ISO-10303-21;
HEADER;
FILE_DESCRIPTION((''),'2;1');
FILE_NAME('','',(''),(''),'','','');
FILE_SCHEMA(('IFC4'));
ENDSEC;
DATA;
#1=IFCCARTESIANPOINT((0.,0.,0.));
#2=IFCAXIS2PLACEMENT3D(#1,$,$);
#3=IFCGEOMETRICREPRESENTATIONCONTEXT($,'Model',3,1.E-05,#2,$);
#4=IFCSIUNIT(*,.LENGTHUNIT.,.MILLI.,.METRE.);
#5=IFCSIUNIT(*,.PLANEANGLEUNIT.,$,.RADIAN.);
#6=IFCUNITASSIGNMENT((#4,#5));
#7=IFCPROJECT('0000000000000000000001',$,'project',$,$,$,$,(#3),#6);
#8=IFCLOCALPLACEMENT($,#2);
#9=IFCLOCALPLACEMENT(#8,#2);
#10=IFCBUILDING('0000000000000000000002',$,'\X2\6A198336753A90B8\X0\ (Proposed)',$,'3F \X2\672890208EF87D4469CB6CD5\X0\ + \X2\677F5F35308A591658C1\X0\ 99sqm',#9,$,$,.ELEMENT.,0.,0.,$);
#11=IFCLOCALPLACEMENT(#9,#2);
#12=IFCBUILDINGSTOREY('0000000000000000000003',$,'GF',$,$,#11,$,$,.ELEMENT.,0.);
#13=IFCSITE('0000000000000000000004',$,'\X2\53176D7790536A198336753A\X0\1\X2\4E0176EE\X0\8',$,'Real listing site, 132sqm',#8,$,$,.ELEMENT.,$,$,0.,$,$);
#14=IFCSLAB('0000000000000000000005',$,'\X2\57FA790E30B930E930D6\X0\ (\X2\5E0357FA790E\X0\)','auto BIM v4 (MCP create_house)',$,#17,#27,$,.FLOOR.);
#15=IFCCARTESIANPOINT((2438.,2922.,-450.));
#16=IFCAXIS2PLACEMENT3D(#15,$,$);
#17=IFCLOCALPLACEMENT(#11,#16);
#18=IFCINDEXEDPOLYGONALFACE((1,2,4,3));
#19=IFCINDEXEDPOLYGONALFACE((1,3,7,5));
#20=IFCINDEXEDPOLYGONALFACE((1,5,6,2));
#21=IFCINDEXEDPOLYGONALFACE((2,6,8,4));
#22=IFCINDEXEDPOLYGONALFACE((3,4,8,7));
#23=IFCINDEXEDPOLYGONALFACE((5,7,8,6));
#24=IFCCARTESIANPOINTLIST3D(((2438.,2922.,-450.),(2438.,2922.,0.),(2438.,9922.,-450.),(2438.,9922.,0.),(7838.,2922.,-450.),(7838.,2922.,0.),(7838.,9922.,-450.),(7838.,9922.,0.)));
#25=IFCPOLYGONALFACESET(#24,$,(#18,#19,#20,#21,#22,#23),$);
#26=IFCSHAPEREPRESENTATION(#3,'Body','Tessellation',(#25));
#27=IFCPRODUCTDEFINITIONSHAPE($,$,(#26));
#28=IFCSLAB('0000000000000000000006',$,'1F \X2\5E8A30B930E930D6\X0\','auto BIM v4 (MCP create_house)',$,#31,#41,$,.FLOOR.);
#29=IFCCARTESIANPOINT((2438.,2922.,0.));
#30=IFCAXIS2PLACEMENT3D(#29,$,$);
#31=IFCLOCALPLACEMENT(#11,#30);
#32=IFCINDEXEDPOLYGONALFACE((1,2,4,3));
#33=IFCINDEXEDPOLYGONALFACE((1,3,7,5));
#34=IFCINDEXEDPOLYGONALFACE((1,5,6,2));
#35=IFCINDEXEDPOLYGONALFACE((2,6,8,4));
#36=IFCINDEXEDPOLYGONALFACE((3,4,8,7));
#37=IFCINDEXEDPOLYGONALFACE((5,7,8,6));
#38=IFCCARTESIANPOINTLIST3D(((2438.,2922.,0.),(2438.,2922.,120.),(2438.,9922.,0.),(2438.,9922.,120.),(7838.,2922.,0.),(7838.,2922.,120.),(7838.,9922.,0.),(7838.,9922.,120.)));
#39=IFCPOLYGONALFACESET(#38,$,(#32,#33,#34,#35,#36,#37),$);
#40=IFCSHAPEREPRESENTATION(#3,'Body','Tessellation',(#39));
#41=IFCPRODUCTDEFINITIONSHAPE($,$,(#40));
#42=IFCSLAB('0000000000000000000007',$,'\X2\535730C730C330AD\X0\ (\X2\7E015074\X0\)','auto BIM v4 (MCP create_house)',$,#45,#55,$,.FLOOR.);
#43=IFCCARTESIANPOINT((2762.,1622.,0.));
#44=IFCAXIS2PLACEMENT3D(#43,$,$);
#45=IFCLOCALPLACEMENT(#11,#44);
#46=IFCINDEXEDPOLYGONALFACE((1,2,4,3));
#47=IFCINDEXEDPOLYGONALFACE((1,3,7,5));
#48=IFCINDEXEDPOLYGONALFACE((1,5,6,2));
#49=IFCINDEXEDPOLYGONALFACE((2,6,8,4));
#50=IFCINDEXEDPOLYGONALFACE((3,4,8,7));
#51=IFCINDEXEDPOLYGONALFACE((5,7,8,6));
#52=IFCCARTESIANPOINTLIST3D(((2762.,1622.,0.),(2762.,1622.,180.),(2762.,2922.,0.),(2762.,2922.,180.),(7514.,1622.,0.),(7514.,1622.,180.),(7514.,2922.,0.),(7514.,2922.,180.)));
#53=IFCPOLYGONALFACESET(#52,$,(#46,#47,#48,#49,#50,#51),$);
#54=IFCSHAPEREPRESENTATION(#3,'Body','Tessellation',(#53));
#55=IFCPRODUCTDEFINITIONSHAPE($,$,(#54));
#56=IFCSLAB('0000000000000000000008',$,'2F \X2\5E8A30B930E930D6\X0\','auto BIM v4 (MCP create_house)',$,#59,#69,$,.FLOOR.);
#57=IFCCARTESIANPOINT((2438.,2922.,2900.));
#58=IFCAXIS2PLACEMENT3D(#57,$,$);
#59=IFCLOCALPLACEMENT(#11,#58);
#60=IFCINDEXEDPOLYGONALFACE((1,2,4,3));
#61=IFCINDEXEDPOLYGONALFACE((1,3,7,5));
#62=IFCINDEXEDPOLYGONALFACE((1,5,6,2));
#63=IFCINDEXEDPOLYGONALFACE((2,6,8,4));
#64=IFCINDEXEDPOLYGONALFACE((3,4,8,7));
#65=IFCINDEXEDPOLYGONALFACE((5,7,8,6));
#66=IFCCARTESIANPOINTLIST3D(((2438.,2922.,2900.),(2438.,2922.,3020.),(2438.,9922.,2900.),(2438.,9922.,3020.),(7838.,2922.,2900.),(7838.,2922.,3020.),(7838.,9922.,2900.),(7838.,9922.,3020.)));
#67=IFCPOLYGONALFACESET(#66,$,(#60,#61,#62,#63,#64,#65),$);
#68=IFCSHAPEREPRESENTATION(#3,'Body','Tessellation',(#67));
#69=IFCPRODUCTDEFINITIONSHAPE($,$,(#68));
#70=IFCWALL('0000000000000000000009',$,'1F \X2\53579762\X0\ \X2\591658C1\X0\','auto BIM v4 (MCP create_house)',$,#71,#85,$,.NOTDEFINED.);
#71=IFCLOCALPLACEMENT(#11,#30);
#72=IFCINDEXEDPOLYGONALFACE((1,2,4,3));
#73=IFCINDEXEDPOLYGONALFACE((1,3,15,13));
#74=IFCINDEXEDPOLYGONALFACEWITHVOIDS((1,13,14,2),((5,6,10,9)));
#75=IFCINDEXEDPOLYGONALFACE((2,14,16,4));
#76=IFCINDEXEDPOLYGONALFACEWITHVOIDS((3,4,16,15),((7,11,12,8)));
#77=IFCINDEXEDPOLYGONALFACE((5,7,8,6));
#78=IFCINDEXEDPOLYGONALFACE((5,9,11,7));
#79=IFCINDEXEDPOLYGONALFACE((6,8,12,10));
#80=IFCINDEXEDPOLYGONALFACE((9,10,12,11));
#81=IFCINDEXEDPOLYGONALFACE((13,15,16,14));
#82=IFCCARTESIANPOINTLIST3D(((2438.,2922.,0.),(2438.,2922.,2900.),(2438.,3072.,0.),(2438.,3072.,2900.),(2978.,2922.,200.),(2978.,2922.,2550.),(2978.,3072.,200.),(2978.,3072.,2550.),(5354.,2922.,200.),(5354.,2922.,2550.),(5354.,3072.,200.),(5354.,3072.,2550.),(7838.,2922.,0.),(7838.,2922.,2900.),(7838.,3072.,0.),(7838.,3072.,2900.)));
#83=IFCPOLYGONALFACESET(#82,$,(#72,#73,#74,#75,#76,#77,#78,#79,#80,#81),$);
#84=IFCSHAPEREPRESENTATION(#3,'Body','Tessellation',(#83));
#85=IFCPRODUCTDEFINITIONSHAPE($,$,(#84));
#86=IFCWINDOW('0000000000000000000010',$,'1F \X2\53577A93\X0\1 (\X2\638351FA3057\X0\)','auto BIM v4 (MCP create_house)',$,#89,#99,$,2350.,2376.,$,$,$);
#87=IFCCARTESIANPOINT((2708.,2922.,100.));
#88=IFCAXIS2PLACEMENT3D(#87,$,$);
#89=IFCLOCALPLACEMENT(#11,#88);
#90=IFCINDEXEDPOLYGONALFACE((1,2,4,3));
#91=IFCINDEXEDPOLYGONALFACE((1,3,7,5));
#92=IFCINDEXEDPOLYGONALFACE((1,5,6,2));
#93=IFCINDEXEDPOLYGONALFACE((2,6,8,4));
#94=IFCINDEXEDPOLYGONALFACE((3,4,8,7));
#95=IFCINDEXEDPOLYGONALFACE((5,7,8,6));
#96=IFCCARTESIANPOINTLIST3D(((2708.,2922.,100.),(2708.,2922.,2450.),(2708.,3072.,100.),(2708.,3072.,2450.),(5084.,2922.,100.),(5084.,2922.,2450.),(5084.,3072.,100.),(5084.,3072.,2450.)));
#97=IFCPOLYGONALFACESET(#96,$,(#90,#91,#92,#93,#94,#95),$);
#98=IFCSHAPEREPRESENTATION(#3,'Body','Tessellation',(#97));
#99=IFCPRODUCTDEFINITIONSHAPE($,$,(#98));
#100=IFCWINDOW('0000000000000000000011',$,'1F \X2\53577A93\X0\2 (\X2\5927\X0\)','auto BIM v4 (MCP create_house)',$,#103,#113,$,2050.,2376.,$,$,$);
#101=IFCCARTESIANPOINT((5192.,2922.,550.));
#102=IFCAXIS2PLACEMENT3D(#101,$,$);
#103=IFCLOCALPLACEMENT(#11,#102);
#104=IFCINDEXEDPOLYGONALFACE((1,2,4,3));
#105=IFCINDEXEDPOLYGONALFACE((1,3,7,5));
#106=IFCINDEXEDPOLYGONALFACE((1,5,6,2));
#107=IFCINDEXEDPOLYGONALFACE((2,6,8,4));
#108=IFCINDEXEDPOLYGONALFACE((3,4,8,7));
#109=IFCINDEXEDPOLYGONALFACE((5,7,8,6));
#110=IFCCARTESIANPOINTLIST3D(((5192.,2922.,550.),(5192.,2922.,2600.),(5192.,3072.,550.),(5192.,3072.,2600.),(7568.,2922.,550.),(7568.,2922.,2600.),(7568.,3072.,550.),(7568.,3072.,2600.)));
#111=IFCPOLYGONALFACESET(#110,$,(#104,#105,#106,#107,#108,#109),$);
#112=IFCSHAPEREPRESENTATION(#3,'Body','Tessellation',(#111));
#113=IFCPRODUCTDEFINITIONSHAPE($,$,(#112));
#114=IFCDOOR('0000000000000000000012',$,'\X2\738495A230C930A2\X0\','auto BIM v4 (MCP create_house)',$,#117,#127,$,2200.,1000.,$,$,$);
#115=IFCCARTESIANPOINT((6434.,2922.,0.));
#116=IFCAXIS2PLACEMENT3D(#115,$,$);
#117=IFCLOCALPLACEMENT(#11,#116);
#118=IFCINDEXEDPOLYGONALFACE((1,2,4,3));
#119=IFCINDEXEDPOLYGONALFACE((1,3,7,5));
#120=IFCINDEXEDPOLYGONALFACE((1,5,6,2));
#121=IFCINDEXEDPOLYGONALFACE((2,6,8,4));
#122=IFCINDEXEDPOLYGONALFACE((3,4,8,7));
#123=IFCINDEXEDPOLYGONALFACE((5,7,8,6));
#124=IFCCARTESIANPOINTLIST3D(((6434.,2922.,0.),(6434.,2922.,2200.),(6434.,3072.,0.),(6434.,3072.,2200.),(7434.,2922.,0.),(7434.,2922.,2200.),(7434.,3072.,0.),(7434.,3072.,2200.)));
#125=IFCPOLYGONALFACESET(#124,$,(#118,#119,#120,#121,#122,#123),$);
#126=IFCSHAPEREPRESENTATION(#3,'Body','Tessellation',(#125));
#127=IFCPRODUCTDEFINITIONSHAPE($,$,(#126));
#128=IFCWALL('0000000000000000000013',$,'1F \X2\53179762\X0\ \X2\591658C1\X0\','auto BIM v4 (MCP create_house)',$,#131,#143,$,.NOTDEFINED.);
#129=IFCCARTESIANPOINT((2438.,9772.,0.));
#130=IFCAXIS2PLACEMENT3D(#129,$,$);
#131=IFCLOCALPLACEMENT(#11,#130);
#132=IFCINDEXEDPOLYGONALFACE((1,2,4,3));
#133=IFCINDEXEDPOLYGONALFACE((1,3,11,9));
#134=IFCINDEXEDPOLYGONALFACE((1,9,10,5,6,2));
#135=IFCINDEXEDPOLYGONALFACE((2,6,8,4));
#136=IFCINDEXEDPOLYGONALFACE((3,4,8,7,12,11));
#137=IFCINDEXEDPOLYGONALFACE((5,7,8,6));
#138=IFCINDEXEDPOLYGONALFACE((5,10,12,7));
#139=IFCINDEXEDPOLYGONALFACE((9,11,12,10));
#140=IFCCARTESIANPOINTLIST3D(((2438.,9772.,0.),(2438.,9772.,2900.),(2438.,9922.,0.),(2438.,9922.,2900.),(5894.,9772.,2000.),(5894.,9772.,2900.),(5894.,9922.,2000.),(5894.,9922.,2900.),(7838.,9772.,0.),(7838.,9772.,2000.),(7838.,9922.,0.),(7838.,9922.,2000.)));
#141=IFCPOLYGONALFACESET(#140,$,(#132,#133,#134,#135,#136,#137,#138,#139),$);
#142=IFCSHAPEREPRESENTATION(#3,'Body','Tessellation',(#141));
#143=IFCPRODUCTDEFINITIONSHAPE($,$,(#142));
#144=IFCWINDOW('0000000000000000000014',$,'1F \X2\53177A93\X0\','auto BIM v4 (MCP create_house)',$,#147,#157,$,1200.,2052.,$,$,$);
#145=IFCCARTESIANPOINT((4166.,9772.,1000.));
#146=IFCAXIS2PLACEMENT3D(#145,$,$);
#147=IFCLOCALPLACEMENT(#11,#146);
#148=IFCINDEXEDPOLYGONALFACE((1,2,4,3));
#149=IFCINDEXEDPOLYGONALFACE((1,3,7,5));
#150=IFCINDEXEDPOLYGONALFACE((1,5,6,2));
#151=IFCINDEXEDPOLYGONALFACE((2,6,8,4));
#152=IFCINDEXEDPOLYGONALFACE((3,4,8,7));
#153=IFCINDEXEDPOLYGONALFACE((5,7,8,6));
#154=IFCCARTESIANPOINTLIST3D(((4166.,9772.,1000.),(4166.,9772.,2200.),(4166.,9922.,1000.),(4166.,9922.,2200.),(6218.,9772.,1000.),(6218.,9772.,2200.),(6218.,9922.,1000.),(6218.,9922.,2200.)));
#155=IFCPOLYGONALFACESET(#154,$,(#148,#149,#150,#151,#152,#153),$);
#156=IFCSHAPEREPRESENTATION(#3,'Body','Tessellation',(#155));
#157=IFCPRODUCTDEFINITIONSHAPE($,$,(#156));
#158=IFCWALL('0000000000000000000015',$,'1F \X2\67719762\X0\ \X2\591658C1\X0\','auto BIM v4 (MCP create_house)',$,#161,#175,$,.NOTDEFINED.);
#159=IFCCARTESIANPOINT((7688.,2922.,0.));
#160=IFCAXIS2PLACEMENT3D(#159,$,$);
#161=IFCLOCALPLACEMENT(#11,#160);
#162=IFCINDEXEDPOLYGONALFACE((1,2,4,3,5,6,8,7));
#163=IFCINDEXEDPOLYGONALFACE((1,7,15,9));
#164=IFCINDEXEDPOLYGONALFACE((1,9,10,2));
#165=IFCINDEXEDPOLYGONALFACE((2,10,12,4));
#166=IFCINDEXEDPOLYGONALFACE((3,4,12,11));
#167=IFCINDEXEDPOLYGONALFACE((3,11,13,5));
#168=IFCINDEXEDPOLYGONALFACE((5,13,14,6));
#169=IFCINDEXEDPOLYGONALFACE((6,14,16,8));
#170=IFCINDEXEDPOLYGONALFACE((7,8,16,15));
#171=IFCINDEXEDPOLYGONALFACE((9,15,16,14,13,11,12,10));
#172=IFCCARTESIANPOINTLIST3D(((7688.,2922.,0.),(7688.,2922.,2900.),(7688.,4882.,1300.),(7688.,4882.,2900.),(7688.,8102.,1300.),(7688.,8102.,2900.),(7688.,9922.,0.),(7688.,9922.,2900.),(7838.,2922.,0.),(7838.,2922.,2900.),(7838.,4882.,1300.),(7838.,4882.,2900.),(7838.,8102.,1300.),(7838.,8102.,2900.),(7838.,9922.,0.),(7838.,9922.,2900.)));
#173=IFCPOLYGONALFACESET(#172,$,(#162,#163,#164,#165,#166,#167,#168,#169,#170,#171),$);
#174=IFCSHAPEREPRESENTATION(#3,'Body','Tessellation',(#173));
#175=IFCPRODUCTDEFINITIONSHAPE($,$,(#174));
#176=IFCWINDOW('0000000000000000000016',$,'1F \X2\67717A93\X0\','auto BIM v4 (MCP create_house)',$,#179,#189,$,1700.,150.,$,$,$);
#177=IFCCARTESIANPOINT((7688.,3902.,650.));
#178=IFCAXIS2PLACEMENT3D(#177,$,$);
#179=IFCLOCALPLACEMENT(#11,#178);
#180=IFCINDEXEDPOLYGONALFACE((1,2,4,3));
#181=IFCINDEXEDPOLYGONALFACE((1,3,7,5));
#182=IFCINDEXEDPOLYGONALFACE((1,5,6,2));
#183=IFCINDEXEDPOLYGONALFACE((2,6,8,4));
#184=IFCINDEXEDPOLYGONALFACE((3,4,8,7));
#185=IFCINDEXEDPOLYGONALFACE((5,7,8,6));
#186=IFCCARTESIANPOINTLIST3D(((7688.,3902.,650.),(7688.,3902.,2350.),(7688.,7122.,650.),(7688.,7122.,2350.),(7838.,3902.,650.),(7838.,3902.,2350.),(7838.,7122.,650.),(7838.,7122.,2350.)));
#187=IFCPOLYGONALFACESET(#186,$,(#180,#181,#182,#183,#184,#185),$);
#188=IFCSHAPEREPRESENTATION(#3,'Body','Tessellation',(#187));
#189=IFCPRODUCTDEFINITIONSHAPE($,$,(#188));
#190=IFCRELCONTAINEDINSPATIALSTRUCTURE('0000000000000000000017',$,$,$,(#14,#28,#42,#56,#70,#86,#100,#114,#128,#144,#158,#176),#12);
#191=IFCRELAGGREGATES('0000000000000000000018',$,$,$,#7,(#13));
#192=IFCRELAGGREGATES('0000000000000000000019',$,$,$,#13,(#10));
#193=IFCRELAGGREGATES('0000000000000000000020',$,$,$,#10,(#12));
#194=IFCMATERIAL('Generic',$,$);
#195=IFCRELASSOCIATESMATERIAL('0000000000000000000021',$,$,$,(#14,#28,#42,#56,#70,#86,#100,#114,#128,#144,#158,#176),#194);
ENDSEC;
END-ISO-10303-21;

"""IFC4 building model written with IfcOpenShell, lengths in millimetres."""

from ifc_helpers import new_model, si_unit, frame, frame_2d, origin, place, context, project, spatial, rectangle, extrude, material, element, fill, save


model = new_model("IFC4")

# Units and contexts
model_context = context("Model", 3, precision=1e-05, world=origin())
ifc_project = project(units=[si_unit("LENGTHUNIT", "METRE", prefix="MILLI"), si_unit("PLANEANGLEUNIT", "RADIAN")], contexts=[model_context])

# Site, building, storey
site_placement = place(None, origin())
site = spatial("IfcSite", under=ifc_project, at=site_placement, Name="北海道標茶町1丁目8", ObjectType="Real listing site, 132sqm", CompositionType="ELEMENT", RefElevation=0.0)
building_placement = place(site_placement, origin())
building = spatial("IfcBuilding", under=site, at=building_placement, Name="標茶町邸 (Proposed)", ObjectType="3F 木造軸組構法 + 板張り外壁 99sqm", CompositionType="ELEMENT", ElevationOfRefHeight=0.0, ElevationOfTerrain=0.0)
storey_placement = place(building_placement, origin())
storey = spatial("IfcBuildingStorey", under=building, at=storey_placement, Name="GF", CompositionType="ELEMENT", Elevation=0.0)

# Slabs
ifc_material = material(Name="Generic")
slab_1_placement = place(storey_placement, frame((2438.0, 2922.0, -450.0)))
element("IfcSlab", 1, at=slab_1_placement, inside=storey, material=ifc_material, Name="基礎スラブ (布基礎)", Description="auto BIM v4 (MCP create_house)", PredefinedType="FLOOR", context=model_context, shape_type="SweptSolid", body=[
    extrude(rectangle(XDim=5400.0, YDim=7000.0, at=frame_2d((2700.0, 3500.0))), frame((2438.0, 2922.0, -450.0)), (0.0, 0.0, 1.0), 450.0),
])
slab_2_placement = place(storey_placement, frame((2438.0, 2922.0, 0.0)))
element("IfcSlab", 2, at=slab_2_placement, inside=storey, material=ifc_material, Name="1F 床スラブ", Description="auto BIM v4 (MCP create_house)", PredefinedType="FLOOR", context=model_context, shape_type="SweptSolid", body=[
    extrude(rectangle(XDim=5400.0, YDim=7000.0, at=frame_2d((2700.0, 3500.0))), frame((2438.0, 2922.0, 0.0)), (0.0, 0.0, 1.0), 120.0),
])
slab_3_placement = place(storey_placement, frame((2762.0, 1622.0, 0.0)))
element("IfcSlab", 3, at=slab_3_placement, inside=storey, material=ifc_material, Name="南デッキ (縁側)", Description="auto BIM v4 (MCP create_house)", PredefinedType="FLOOR", context=model_context, shape_type="SweptSolid", body=[
    extrude(rectangle(XDim=4752.0, YDim=1300.0, at=frame_2d((2376.0, 650.0))), frame((2762.0, 1622.0, 0.0)), (0.0, 0.0, 1.0), 180.0),
])
slab_4_placement = place(storey_placement, frame((2438.0, 2922.0, 2900.0)))
element("IfcSlab", 4, at=slab_4_placement, inside=storey, material=ifc_material, Name="2F 床スラブ", Description="auto BIM v4 (MCP create_house)", PredefinedType="FLOOR", context=model_context, shape_type="SweptSolid", body=[
    extrude(rectangle(XDim=5400.0, YDim=7000.0, at=frame_2d((2700.0, 3500.0))), frame((2438.0, 2922.0, 2900.0)), (0.0, 0.0, 1.0), 120.0),
])

# Wall, openings, windows, door
wall_1_placement = place(storey_placement, frame((2438.0, 2922.0, 0.0)))
wall_1 = element("IfcWall", 5, at=wall_1_placement, inside=storey, material=ifc_material, Name="1F 南面 外壁", Description="auto BIM v4 (MCP create_house)", PredefinedType="NOTDEFINED", context=model_context, shape_type="SweptSolid", body=[
    extrude(rectangle(XDim=5400.0, YDim=150.0, at=frame_2d((2700.0, 75.0))), frame((2438.0, 2922.0, 0.0)), (0.0, 0.0, 1.0), 2900.0),
])
opening_1_placement = place(storey_placement, frame((2708.0, 2922.0, 100.0)))
opening_1 = element("IfcOpeningElement", 6, at=opening_1_placement, cuts=wall_1, PredefinedType="NOTDEFINED", context=model_context, shape_type="SweptSolid", body=[
    extrude(rectangle(XDim=2376.0, YDim=150.0, at=frame_2d((1188.0, 75.0))), frame((2708.0, 2922.0, 100.0)), (0.0, 0.0, 1.0), 2350.0),
])
opening_2_placement = place(storey_placement, frame((5192.0, 2922.0, 550.0)))
opening_2 = element("IfcOpeningElement", 7, at=opening_2_placement, cuts=wall_1, PredefinedType="NOTDEFINED", context=model_context, shape_type="SweptSolid", body=[
    extrude(rectangle(XDim=2376.0, YDim=150.0, at=frame_2d((1188.0, 75.0))), frame((5192.0, 2922.0, 550.0)), (0.0, 0.0, 1.0), 2050.0),
])
opening_3_placement = place(storey_placement, frame((6434.0, 2922.0, 0.0)))
opening_3 = element("IfcOpeningElement", 8, at=opening_3_placement, cuts=wall_1, PredefinedType="NOTDEFINED", context=model_context, shape_type="SweptSolid", body=[
    extrude(rectangle(XDim=1000.0, YDim=150.0, at=frame_2d((500.0, 75.0))), frame((6434.0, 2922.0, 0.0)), (0.0, 0.0, 1.0), 2200.0),
])
window_1_placement = place(storey_placement, frame((2708.0, 2922.0, 100.0)))
window_1 = element("IfcWindow", 9, at=window_1_placement, inside=storey, material=ifc_material, Name="1F 南窓1 (掃出し)", Description="auto BIM v4 (MCP create_house)", OverallHeight=2350.0, OverallWidth=2376.0, context=model_context, shape_type="SweptSolid", body=[
    extrude(rectangle(XDim=2376.0, YDim=150.0, at=frame_2d((1188.0, 75.0))), frame((2708.0, 2922.0, 100.0)), (0.0, 0.0, 1.0), 2350.0),
])
fill(opening_1, window_1)
window_2_placement = place(storey_placement, frame((5192.0, 2922.0, 550.0)))
window_2 = element("IfcWindow", 10, at=window_2_placement, inside=storey, material=ifc_material, Name="1F 南窓2 (大)", Description="auto BIM v4 (MCP create_house)", OverallHeight=2050.0, OverallWidth=2376.0, context=model_context, shape_type="SweptSolid", body=[
    extrude(rectangle(XDim=2376.0, YDim=150.0, at=frame_2d((1188.0, 75.0))), frame((5192.0, 2922.0, 550.0)), (0.0, 0.0, 1.0), 2050.0),
])
fill(opening_2, window_2)
door_placement = place(storey_placement, frame((6434.0, 2922.0, 0.0)))
door = element("IfcDoor", 11, at=door_placement, inside=storey, material=ifc_material, Name="玄関ドア", Description="auto BIM v4 (MCP create_house)", OverallHeight=2200.0, OverallWidth=1000.0, context=model_context, shape_type="SweptSolid", body=[
    extrude(rectangle(XDim=1000.0, YDim=150.0, at=frame_2d((500.0, 75.0))), frame((6434.0, 2922.0, 0.0)), (0.0, 0.0, 1.0), 2200.0),
])
fill(opening_3, door)

# Walls, openings, windows
wall_2_placement = place(storey_placement, frame((2438.0, 9772.0, 0.0)))
wall_2 = element("IfcWall", 12, at=wall_2_placement, inside=storey, material=ifc_material, Name="1F 北面 外壁", Description="auto BIM v4 (MCP create_house)", PredefinedType="NOTDEFINED", context=model_context, shape_type="SweptSolid", body=[
    extrude(rectangle(XDim=5400.0, YDim=150.0, at=frame_2d((2700.0, 75.0))), frame((2438.0, 9772.0, 0.0)), (0.0, 0.0, 1.0), 2900.0),
])
opening_4_placement = place(storey_placement, frame((4166.0, 9772.0, 1000.0)))
opening_4 = element("IfcOpeningElement", 13, at=opening_4_placement, cuts=wall_2, PredefinedType="NOTDEFINED", context=model_context, shape_type="SweptSolid", body=[
    extrude(rectangle(XDim=2052.0, YDim=150.0, at=frame_2d((1026.0, 75.0))), frame((4166.0, 9772.0, 1000.0)), (0.0, 0.0, 1.0), 1200.0),
])
window_3_placement = place(storey_placement, frame((4166.0, 9772.0, 1000.0)))
window_3 = element("IfcWindow", 14, at=window_3_placement, inside=storey, material=ifc_material, Name="1F 北窓", Description="auto BIM v4 (MCP create_house)", OverallHeight=1200.0, OverallWidth=2052.0, context=model_context, shape_type="SweptSolid", body=[
    extrude(rectangle(XDim=2052.0, YDim=150.0, at=frame_2d((1026.0, 75.0))), frame((4166.0, 9772.0, 1000.0)), (0.0, 0.0, 1.0), 1200.0),
])
fill(opening_4, window_3)
wall_3_placement = place(storey_placement, frame((7688.0, 2922.0, 0.0)))
wall_3 = element("IfcWall", 15, at=wall_3_placement, inside=storey, material=ifc_material, Name="1F 東面 外壁", Description="auto BIM v4 (MCP create_house)", PredefinedType="NOTDEFINED", context=model_context, shape_type="SweptSolid", body=[
    extrude(rectangle(XDim=150.0, YDim=7000.0, at=frame_2d((75.0, 3500.0))), frame((7688.0, 2922.0, 0.0)), (0.0, 0.0, 1.0), 2900.0),
])
opening_5_placement = place(storey_placement, frame((7688.0, 3902.0, 650.0)))
opening_5 = element("IfcOpeningElement", 16, at=opening_5_placement, cuts=wall_3, PredefinedType="NOTDEFINED", context=model_context, shape_type="SweptSolid", body=[
    extrude(rectangle(XDim=150.0, YDim=3220.0, at=frame_2d((75.0, 1610.0))), frame((7688.0, 3902.0, 650.0)), (0.0, 0.0, 1.0), 1700.0),
])
window_4_placement = place(storey_placement, frame((7688.0, 3902.0, 650.0)))
window_4 = element("IfcWindow", 17, at=window_4_placement, inside=storey, material=ifc_material, Name="1F 東窓", Description="auto BIM v4 (MCP create_house)", OverallHeight=1700.0, OverallWidth=150.0, context=model_context, shape_type="SweptSolid", body=[
    extrude(rectangle(XDim=150.0, YDim=3220.0, at=frame_2d((75.0, 1610.0))), frame((7688.0, 3902.0, 650.0)), (0.0, 0.0, 1.0), 1700.0),
])
fill(opening_5, window_4)

save(model, "model.ifc")
